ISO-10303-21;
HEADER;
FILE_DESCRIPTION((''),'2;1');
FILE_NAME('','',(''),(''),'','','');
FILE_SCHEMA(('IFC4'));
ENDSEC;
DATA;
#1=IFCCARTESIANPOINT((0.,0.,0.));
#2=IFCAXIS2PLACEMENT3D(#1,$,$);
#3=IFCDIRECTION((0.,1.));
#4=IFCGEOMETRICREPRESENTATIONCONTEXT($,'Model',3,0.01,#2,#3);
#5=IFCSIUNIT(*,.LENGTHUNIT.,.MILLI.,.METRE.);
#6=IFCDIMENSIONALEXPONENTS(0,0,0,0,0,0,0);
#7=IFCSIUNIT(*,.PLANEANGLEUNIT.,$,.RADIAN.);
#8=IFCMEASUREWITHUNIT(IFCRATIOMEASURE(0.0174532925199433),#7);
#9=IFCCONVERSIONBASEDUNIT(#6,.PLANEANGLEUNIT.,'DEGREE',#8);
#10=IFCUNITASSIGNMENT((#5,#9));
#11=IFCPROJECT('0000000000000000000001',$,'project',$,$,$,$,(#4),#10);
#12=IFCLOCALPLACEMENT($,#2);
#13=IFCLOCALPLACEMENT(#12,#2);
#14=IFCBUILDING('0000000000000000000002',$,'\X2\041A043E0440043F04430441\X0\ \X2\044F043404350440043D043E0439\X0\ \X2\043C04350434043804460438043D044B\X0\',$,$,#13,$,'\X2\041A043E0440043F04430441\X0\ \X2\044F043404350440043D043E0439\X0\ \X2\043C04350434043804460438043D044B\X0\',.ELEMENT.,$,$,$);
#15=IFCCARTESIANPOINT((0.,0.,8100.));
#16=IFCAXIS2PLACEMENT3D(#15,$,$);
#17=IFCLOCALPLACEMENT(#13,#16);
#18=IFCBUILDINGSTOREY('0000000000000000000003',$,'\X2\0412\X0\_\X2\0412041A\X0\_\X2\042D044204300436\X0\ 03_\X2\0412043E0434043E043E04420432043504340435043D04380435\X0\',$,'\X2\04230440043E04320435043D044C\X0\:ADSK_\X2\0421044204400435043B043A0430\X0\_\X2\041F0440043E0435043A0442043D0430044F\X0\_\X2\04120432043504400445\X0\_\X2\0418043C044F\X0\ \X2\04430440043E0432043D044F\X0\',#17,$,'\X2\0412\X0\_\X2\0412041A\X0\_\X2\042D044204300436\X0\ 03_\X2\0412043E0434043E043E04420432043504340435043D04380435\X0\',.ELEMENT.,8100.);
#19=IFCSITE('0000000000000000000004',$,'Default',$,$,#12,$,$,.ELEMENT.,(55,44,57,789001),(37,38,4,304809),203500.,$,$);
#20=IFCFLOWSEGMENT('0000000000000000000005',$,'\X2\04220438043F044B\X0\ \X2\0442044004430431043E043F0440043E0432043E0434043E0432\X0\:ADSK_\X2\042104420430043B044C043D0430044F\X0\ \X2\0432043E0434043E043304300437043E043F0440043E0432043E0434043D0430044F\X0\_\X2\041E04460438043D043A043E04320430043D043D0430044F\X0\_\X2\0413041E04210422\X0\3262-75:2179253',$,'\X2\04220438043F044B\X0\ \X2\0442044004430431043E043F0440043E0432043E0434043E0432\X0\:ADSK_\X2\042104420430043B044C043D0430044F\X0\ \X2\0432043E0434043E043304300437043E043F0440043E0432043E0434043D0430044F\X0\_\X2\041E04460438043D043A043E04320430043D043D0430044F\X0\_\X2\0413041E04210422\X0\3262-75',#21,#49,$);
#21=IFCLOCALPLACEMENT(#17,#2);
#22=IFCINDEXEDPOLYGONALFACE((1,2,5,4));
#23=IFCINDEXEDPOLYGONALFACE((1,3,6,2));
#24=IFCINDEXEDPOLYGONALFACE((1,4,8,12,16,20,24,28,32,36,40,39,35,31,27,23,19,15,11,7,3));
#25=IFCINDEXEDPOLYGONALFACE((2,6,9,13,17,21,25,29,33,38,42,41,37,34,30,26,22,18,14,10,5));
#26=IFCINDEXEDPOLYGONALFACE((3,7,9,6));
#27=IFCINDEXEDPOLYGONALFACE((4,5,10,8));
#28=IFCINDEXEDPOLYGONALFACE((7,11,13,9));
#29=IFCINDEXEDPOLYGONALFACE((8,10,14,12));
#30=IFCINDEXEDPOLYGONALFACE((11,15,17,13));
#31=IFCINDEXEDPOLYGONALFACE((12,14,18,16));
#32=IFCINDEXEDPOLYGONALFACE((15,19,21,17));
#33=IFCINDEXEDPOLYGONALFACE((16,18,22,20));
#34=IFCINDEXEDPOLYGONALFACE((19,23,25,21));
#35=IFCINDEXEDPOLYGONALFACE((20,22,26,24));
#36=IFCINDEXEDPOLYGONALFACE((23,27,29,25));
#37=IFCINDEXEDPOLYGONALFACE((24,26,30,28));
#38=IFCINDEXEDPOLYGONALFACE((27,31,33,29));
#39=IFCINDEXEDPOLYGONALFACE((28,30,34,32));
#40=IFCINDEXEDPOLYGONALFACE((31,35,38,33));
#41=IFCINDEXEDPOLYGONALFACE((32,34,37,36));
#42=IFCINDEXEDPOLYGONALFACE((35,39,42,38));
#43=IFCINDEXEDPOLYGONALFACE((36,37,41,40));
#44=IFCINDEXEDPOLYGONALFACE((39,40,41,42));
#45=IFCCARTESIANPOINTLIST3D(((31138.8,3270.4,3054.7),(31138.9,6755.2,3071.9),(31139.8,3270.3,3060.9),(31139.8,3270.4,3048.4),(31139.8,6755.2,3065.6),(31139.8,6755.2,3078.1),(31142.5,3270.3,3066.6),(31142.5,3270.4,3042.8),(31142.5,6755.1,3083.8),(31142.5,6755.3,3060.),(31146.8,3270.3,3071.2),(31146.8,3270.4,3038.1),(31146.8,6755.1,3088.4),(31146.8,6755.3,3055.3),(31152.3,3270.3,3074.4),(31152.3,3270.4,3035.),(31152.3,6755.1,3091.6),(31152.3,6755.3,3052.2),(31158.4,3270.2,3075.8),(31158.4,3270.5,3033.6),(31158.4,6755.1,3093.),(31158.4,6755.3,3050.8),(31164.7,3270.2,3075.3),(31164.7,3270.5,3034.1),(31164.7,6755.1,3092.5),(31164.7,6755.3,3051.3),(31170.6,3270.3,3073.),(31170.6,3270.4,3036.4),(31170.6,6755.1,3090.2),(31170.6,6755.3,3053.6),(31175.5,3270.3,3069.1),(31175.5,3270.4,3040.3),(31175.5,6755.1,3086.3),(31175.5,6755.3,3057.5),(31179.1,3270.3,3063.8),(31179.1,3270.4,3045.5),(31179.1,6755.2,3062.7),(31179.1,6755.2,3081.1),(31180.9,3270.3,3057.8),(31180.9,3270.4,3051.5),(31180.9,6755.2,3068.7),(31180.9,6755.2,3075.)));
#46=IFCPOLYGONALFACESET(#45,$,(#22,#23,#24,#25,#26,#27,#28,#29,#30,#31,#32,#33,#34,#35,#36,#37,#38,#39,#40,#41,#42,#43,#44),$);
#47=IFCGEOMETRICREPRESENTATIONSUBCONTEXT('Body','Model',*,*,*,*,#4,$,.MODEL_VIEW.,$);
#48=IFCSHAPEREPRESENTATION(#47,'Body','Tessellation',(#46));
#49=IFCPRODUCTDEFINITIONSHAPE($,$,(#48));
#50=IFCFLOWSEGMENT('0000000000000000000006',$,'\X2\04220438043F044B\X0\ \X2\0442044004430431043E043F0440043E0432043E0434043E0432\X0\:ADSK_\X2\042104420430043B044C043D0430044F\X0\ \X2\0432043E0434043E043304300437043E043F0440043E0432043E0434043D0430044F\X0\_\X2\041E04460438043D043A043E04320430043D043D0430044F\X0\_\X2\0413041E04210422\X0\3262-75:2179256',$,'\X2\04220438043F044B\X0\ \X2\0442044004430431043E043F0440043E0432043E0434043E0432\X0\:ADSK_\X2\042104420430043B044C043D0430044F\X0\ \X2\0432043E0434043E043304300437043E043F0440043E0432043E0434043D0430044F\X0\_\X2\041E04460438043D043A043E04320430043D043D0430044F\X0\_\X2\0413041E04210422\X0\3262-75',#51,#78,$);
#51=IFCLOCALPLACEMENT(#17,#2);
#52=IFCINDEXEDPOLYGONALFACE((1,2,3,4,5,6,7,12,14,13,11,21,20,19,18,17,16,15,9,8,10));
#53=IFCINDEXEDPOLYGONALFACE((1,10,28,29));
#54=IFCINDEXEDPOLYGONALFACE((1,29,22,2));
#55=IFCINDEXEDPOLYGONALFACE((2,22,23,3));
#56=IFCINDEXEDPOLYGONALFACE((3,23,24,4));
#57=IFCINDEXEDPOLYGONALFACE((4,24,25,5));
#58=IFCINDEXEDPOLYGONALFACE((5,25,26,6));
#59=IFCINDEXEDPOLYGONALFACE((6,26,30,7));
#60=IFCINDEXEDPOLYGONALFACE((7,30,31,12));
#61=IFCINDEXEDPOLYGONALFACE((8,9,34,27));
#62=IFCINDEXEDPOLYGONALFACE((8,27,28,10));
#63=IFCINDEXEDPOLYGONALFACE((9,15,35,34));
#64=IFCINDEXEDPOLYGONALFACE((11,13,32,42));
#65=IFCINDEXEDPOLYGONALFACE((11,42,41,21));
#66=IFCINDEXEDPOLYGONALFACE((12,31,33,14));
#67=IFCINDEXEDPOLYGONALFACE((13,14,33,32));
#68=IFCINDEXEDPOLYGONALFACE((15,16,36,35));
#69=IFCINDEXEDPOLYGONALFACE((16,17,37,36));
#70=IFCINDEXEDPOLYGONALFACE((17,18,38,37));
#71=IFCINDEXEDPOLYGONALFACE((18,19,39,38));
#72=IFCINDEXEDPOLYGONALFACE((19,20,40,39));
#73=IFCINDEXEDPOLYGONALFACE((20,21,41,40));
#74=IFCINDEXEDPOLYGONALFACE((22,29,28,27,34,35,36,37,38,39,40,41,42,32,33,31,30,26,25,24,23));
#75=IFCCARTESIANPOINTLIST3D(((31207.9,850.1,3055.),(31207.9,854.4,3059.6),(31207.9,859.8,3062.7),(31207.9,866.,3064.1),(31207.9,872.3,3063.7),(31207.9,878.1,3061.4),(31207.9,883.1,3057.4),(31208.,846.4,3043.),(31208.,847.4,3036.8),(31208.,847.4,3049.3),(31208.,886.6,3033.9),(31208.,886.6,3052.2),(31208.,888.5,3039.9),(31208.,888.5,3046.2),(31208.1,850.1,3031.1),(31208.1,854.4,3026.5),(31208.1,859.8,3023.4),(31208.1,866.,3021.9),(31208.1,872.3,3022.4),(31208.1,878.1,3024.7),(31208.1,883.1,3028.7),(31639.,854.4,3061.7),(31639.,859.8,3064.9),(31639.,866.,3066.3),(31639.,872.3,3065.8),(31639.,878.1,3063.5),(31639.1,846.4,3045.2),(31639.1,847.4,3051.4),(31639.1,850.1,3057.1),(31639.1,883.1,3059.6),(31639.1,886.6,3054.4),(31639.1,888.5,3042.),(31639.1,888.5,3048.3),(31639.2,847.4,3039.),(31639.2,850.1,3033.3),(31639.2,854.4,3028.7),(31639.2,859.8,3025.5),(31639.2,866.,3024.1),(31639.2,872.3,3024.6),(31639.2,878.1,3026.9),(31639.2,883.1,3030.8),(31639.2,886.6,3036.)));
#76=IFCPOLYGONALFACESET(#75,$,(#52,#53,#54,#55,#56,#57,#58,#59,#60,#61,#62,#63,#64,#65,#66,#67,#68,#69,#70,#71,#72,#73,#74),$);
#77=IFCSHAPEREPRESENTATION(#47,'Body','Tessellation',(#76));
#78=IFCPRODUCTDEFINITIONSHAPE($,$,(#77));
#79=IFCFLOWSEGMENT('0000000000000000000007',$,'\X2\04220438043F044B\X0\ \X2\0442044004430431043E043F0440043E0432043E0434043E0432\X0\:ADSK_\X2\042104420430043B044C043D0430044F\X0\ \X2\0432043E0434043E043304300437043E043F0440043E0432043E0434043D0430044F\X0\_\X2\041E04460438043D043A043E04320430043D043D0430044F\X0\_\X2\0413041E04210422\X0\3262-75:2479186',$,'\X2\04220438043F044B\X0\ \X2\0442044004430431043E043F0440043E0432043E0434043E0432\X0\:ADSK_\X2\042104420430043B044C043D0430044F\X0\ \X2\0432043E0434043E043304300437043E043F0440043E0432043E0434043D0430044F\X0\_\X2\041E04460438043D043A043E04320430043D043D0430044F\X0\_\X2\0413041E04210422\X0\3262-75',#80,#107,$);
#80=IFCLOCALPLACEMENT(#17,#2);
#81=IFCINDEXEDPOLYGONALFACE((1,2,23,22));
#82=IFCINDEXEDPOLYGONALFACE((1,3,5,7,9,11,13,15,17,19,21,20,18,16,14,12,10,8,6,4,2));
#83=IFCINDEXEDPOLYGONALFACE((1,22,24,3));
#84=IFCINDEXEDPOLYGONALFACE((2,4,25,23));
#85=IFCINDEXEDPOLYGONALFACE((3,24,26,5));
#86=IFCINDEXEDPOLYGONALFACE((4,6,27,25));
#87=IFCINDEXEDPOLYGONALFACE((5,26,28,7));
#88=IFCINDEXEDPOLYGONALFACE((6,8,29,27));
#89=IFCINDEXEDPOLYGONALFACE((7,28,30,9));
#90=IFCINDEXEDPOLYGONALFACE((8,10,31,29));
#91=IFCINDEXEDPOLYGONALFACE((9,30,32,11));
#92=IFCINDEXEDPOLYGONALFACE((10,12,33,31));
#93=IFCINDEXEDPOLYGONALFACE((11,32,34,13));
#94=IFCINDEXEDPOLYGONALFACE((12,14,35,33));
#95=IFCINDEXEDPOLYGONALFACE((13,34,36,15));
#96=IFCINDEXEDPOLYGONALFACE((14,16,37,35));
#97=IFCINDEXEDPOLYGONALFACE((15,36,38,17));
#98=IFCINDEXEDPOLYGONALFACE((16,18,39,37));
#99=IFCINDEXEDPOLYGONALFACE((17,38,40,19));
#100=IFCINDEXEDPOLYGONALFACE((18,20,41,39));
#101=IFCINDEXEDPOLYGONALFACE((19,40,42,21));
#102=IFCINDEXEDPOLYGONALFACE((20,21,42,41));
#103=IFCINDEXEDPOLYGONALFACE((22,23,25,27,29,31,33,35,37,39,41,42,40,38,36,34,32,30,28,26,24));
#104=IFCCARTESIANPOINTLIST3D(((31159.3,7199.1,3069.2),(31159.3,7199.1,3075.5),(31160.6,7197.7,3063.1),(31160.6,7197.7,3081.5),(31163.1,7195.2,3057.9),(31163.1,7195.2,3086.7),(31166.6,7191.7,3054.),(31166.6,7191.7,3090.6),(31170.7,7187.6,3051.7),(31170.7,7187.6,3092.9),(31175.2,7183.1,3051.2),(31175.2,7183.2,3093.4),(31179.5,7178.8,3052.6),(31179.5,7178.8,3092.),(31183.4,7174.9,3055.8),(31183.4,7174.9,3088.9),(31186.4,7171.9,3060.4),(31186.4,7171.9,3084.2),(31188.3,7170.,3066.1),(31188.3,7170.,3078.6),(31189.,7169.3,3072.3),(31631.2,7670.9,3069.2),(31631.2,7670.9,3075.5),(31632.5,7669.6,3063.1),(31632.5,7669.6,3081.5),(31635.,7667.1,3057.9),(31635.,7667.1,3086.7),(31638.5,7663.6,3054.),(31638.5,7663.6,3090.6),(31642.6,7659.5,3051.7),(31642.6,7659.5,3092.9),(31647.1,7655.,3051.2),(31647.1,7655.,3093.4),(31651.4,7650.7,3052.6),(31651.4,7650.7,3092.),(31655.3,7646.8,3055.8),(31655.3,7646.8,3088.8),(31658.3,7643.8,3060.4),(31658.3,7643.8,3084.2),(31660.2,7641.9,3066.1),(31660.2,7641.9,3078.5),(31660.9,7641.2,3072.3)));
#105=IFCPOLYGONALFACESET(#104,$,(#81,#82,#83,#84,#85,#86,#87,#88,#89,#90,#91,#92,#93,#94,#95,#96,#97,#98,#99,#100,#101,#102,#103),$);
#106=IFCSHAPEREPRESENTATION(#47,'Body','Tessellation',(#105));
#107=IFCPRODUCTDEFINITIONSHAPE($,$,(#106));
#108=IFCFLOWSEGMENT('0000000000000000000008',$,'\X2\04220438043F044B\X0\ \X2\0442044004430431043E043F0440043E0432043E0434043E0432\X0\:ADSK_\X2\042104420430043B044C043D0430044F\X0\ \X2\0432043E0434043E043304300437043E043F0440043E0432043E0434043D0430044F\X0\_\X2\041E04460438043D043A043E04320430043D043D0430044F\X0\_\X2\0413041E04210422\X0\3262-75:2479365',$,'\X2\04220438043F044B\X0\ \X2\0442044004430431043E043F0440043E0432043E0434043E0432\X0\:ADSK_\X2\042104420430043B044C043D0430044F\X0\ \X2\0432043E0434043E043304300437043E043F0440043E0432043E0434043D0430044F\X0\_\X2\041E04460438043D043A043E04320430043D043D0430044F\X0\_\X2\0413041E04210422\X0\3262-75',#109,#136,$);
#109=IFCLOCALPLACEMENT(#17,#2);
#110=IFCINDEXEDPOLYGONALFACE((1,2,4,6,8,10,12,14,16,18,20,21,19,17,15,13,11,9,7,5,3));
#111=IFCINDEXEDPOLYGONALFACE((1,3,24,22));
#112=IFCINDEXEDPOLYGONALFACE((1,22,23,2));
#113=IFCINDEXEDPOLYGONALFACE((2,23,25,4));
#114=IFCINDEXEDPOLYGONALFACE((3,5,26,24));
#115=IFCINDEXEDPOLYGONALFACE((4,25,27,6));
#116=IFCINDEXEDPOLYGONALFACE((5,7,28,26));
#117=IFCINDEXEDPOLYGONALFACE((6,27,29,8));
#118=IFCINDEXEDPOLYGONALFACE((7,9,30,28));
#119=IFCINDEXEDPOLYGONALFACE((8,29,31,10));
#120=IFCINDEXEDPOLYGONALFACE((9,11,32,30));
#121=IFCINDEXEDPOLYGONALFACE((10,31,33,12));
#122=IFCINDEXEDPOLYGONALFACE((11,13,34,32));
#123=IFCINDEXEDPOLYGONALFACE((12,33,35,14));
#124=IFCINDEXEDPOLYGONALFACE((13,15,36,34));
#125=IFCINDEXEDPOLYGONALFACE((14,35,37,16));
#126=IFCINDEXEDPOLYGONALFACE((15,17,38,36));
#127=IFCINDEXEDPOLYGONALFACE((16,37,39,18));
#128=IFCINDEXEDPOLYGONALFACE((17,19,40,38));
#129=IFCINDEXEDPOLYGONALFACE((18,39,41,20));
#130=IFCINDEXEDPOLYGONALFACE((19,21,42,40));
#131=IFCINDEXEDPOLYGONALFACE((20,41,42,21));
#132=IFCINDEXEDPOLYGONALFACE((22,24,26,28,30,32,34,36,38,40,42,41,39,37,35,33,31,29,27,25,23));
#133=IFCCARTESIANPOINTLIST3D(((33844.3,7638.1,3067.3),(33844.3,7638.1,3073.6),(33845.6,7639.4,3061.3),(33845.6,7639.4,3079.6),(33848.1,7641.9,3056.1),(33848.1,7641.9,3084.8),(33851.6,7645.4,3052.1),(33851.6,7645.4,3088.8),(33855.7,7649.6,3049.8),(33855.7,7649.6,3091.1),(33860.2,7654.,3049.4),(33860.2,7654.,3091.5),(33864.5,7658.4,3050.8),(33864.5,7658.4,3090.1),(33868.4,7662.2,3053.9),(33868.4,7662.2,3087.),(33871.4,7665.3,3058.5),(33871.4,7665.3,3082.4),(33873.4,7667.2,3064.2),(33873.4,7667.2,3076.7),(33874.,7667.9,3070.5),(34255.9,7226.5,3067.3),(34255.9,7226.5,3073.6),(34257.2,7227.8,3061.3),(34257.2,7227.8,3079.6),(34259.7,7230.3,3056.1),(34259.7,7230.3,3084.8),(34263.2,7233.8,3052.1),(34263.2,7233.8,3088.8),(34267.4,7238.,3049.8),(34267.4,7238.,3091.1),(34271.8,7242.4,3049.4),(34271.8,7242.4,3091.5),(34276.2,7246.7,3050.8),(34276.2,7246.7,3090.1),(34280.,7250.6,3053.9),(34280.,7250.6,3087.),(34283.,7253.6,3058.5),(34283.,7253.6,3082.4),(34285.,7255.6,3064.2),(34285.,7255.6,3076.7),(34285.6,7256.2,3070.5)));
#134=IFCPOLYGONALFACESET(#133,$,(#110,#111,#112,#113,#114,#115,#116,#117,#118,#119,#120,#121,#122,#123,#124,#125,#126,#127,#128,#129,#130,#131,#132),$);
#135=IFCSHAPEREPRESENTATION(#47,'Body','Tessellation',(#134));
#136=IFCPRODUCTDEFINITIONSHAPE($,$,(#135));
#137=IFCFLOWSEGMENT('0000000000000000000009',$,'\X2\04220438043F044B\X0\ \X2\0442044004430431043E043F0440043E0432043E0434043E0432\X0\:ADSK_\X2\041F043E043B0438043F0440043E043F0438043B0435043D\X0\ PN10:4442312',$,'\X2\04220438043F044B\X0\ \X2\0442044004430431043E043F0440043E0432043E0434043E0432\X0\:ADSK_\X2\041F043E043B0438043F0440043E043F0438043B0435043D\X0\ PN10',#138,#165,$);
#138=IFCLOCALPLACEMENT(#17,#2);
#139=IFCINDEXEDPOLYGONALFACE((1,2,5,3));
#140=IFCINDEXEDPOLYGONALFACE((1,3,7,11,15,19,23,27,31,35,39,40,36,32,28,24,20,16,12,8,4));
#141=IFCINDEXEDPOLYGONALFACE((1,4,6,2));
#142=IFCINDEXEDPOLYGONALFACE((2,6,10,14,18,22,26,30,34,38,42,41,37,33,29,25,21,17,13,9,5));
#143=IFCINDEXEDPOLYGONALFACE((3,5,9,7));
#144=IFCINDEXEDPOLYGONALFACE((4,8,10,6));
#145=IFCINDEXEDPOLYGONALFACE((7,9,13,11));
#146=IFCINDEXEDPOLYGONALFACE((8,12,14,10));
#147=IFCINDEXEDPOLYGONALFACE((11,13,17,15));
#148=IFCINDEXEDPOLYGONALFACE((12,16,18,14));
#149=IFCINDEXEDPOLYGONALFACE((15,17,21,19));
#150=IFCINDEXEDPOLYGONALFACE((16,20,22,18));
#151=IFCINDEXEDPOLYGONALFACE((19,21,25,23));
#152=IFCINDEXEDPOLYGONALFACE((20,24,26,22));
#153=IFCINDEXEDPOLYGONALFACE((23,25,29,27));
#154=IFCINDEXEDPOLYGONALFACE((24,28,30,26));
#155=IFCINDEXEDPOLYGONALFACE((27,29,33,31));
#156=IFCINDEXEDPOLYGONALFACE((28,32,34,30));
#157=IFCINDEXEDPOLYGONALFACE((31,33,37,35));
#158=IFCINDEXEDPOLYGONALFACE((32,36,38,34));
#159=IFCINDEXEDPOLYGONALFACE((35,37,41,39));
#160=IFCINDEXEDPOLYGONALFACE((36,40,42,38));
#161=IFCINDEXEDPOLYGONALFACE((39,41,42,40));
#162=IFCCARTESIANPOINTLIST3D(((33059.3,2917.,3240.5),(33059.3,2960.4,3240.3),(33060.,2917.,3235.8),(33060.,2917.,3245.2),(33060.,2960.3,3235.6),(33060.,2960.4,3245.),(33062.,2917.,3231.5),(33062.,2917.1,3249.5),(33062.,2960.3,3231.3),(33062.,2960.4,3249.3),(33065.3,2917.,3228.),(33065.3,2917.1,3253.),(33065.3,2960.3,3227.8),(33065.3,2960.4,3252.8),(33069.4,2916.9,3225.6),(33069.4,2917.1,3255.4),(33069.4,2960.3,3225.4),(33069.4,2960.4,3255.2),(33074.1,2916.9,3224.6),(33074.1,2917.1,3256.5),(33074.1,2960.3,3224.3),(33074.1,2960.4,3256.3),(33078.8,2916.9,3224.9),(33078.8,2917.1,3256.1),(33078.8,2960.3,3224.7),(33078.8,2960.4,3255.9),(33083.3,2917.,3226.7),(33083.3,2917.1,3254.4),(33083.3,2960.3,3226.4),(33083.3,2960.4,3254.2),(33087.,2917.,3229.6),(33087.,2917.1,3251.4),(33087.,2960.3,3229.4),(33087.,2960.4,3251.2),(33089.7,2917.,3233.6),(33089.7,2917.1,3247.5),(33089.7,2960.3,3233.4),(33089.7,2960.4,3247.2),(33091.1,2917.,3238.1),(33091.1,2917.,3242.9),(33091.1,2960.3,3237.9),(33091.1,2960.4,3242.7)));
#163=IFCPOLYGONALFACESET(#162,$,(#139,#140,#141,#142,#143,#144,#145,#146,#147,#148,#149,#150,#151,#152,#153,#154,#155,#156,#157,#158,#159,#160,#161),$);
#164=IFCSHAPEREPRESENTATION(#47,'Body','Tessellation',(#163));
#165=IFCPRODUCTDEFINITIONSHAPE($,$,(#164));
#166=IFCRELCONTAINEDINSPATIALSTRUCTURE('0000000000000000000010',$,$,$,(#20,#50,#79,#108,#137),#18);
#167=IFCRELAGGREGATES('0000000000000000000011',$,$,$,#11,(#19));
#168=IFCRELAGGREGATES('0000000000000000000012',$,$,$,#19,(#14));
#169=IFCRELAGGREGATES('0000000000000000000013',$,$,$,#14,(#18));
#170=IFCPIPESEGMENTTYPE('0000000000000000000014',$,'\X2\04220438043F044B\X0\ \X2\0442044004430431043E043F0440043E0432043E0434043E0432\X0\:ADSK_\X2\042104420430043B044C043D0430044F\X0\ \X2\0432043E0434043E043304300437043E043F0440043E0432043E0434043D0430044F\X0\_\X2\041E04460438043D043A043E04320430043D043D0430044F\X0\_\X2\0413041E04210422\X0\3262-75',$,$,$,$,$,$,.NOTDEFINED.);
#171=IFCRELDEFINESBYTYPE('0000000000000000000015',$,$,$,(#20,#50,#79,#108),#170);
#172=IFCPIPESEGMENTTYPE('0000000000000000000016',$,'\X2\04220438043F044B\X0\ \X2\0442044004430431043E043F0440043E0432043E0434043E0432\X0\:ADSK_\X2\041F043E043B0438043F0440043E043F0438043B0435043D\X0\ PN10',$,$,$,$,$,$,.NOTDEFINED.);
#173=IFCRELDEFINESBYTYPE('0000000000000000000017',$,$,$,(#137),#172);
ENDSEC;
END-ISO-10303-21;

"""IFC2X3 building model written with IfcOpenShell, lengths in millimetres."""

from ifc_helpers import new_model, entity, si_unit, converted_unit, direction, frame, origin, origin_2d_with_axis, place, context, subcontext, project, spatial, circle, extrude, type_object, element, save


model = new_model("IFC2X3")

# Units and contexts
model_context = context("Model", 3, precision=0.01, world=origin(), true_north=direction((0.0, 1.0)))
body_context = subcontext(model_context, "Body", "Model", "MODEL_VIEW")
ifc_project = project(units=[si_unit("LENGTHUNIT", "METRE", prefix="MILLI"), converted_unit("PLANEANGLEUNIT", "DEGREE", entity("IfcRatioMeasure", 0.0174532925199433), si_unit("PLANEANGLEUNIT", "RADIAN"), dimensions=[0, 0, 0, 0, 0, 0, 0])], contexts=[model_context])

# Site, building, storey
site_placement = place(None, origin())
site = spatial("IfcSite", under=ifc_project, at=site_placement, Name="Default", CompositionType="ELEMENT", RefLatitude=(55, 44, 57, 789001), RefLongitude=(37, 38, 4, 304809), RefElevation=203500.0)
building_placement = place(site_placement, origin())
building = spatial("IfcBuilding", under=site, at=building_placement, Name="Корпус ядерной медицины", LongName="Корпус ядерной медицины", CompositionType="ELEMENT")
storey_placement = place(building_placement, frame((0.0, 0.0, 8100.0)))
storey = spatial("IfcBuildingStorey", under=building, at=storey_placement, Name="В_ВК_Этаж 03_Водоотведение", ObjectType="Уровень:ADSK_Стрелка_Проектная_Вверх_Имя уровня", LongName="В_ВК_Этаж 03_Водоотведение", CompositionType="ELEMENT", Elevation=8100.0)

# Flow segments
pipe_segment_type_1 = type_object("IfcPipeSegmentType", Name="Типы трубопроводов:ADSK_Стальная водогазопроводная_Оцинкованная_ГОСТ3262-75", PredefinedType="NOTDEFINED")
flow_segment_1_placement = place(storey_placement, frame((31137.2, 3270.2, 3031.9)))
element("IfcFlowSegment", 1, at=flow_segment_1_placement, inside=storey, type_object=pipe_segment_type_1, Name="Типы трубопроводов:ADSK_Стальная водогазопроводная_Оцинкованная_ГОСТ3262-75:2179253", ObjectType="Типы трубопроводов:ADSK_Стальная водогазопроводная_Оцинкованная_ГОСТ3262-75", context=body_context, shape_type="SweptSolid", body=[
    extrude(circle(Radius=21.1, at=origin_2d_with_axis()), frame((22.8, 0.1, 22.8), z_axis=(0.0, 0.999988, 0.004938), x_axis=(-1.0, 0.0, 0.0)), (0.0, 0.0, 1.0), 3484.9),
])
flow_segment_2_placement = place(storey_placement, frame((31207.9, 844.8, 3020.3)))
element("IfcFlowSegment", 2, at=flow_segment_2_placement, inside=storey, type_object=pipe_segment_type_1, Name="Типы трубопроводов:ADSK_Стальная водогазопроводная_Оцинкованная_ГОСТ3262-75:2179256", ObjectType="Типы трубопроводов:ADSK_Стальная водогазопроводная_Оцинкованная_ГОСТ3262-75", context=body_context, shape_type="SweptSolid", body=[
    extrude(circle(Radius=21.1, at=origin_2d_with_axis()), frame((0.1, 22.8, 22.8), z_axis=(0.999987, -0.000012, 0.005), x_axis=(-0.000012, -1.0, 0.0)), (0.0, 0.0, 1.0), 431.1),
])
flow_segment_3_placement = place(storey_placement, frame((31157.5, 7167.7, 3049.6)))
element("IfcFlowSegment", 3, at=flow_segment_3_placement, inside=storey, type_object=pipe_segment_type_1, Name="Типы трубопроводов:ADSK_Стальная водогазопроводная_Оцинкованная_ГОСТ3262-75:2479186", ObjectType="Типы трубопроводов:ADSK_Стальная водогазопроводная_Оцинкованная_ГОСТ3262-75", context=body_context, shape_type="SweptSolid", body=[
    extrude(circle(Radius=21.1, at=origin_2d_with_axis()), frame((488.4, 488.4, 22.8), z_axis=(-0.707107, -0.707107, 0.000022), x_axis=(0.707107, -0.707107, 0.0)), (0.0, 0.0, 1.0), 667.3),
])
flow_segment_4_placement = place(storey_placement, frame((33842.5, 7224.7, 3047.7)))
element("IfcFlowSegment", 4, at=flow_segment_4_placement, inside=storey, type_object=pipe_segment_type_1, Name="Типы трубопроводов:ADSK_Стальная водогазопроводная_Оцинкованная_ГОСТ3262-75:2479365", ObjectType="Типы трубопроводов:ADSK_Стальная водогазопроводная_Оцинкованная_ГОСТ3262-75", context=body_context, shape_type="SweptSolid", body=[
    extrude(circle(Radius=21.1, at=origin_2d_with_axis()), frame((16.6, 428.2, 22.8), z_axis=(0.707107, -0.707107, 0.0), x_axis=(0.707107, 0.707107, 0.0)), (0.0, 0.0, 1.0), 582.1),
])
pipe_segment_type_2 = type_object("IfcPipeSegmentType", Name="Типы трубопроводов:ADSK_Полипропилен PN10", PredefinedType="NOTDEFINED")
flow_segment_5_placement = place(storey_placement, frame((33057.7, 2916.9, 3222.7)))
element("IfcFlowSegment", 5, at=flow_segment_5_placement, inside=storey, type_object=pipe_segment_type_2, Name="Типы трубопроводов:ADSK_Полипропилен PN10:4442312", ObjectType="Типы трубопроводов:ADSK_Полипропилен PN10", context=body_context, shape_type="SweptSolid", body=[
    extrude(circle(Radius=16.0, at=origin_2d_with_axis()), frame((17.6, 0.1, 17.8), z_axis=(0.0, 0.999988, -0.004906), x_axis=(-1.0, 0.0, 0.0)), (0.0, 0.0, 1.0), 43.3),
])

save(model, "model.ifc")
